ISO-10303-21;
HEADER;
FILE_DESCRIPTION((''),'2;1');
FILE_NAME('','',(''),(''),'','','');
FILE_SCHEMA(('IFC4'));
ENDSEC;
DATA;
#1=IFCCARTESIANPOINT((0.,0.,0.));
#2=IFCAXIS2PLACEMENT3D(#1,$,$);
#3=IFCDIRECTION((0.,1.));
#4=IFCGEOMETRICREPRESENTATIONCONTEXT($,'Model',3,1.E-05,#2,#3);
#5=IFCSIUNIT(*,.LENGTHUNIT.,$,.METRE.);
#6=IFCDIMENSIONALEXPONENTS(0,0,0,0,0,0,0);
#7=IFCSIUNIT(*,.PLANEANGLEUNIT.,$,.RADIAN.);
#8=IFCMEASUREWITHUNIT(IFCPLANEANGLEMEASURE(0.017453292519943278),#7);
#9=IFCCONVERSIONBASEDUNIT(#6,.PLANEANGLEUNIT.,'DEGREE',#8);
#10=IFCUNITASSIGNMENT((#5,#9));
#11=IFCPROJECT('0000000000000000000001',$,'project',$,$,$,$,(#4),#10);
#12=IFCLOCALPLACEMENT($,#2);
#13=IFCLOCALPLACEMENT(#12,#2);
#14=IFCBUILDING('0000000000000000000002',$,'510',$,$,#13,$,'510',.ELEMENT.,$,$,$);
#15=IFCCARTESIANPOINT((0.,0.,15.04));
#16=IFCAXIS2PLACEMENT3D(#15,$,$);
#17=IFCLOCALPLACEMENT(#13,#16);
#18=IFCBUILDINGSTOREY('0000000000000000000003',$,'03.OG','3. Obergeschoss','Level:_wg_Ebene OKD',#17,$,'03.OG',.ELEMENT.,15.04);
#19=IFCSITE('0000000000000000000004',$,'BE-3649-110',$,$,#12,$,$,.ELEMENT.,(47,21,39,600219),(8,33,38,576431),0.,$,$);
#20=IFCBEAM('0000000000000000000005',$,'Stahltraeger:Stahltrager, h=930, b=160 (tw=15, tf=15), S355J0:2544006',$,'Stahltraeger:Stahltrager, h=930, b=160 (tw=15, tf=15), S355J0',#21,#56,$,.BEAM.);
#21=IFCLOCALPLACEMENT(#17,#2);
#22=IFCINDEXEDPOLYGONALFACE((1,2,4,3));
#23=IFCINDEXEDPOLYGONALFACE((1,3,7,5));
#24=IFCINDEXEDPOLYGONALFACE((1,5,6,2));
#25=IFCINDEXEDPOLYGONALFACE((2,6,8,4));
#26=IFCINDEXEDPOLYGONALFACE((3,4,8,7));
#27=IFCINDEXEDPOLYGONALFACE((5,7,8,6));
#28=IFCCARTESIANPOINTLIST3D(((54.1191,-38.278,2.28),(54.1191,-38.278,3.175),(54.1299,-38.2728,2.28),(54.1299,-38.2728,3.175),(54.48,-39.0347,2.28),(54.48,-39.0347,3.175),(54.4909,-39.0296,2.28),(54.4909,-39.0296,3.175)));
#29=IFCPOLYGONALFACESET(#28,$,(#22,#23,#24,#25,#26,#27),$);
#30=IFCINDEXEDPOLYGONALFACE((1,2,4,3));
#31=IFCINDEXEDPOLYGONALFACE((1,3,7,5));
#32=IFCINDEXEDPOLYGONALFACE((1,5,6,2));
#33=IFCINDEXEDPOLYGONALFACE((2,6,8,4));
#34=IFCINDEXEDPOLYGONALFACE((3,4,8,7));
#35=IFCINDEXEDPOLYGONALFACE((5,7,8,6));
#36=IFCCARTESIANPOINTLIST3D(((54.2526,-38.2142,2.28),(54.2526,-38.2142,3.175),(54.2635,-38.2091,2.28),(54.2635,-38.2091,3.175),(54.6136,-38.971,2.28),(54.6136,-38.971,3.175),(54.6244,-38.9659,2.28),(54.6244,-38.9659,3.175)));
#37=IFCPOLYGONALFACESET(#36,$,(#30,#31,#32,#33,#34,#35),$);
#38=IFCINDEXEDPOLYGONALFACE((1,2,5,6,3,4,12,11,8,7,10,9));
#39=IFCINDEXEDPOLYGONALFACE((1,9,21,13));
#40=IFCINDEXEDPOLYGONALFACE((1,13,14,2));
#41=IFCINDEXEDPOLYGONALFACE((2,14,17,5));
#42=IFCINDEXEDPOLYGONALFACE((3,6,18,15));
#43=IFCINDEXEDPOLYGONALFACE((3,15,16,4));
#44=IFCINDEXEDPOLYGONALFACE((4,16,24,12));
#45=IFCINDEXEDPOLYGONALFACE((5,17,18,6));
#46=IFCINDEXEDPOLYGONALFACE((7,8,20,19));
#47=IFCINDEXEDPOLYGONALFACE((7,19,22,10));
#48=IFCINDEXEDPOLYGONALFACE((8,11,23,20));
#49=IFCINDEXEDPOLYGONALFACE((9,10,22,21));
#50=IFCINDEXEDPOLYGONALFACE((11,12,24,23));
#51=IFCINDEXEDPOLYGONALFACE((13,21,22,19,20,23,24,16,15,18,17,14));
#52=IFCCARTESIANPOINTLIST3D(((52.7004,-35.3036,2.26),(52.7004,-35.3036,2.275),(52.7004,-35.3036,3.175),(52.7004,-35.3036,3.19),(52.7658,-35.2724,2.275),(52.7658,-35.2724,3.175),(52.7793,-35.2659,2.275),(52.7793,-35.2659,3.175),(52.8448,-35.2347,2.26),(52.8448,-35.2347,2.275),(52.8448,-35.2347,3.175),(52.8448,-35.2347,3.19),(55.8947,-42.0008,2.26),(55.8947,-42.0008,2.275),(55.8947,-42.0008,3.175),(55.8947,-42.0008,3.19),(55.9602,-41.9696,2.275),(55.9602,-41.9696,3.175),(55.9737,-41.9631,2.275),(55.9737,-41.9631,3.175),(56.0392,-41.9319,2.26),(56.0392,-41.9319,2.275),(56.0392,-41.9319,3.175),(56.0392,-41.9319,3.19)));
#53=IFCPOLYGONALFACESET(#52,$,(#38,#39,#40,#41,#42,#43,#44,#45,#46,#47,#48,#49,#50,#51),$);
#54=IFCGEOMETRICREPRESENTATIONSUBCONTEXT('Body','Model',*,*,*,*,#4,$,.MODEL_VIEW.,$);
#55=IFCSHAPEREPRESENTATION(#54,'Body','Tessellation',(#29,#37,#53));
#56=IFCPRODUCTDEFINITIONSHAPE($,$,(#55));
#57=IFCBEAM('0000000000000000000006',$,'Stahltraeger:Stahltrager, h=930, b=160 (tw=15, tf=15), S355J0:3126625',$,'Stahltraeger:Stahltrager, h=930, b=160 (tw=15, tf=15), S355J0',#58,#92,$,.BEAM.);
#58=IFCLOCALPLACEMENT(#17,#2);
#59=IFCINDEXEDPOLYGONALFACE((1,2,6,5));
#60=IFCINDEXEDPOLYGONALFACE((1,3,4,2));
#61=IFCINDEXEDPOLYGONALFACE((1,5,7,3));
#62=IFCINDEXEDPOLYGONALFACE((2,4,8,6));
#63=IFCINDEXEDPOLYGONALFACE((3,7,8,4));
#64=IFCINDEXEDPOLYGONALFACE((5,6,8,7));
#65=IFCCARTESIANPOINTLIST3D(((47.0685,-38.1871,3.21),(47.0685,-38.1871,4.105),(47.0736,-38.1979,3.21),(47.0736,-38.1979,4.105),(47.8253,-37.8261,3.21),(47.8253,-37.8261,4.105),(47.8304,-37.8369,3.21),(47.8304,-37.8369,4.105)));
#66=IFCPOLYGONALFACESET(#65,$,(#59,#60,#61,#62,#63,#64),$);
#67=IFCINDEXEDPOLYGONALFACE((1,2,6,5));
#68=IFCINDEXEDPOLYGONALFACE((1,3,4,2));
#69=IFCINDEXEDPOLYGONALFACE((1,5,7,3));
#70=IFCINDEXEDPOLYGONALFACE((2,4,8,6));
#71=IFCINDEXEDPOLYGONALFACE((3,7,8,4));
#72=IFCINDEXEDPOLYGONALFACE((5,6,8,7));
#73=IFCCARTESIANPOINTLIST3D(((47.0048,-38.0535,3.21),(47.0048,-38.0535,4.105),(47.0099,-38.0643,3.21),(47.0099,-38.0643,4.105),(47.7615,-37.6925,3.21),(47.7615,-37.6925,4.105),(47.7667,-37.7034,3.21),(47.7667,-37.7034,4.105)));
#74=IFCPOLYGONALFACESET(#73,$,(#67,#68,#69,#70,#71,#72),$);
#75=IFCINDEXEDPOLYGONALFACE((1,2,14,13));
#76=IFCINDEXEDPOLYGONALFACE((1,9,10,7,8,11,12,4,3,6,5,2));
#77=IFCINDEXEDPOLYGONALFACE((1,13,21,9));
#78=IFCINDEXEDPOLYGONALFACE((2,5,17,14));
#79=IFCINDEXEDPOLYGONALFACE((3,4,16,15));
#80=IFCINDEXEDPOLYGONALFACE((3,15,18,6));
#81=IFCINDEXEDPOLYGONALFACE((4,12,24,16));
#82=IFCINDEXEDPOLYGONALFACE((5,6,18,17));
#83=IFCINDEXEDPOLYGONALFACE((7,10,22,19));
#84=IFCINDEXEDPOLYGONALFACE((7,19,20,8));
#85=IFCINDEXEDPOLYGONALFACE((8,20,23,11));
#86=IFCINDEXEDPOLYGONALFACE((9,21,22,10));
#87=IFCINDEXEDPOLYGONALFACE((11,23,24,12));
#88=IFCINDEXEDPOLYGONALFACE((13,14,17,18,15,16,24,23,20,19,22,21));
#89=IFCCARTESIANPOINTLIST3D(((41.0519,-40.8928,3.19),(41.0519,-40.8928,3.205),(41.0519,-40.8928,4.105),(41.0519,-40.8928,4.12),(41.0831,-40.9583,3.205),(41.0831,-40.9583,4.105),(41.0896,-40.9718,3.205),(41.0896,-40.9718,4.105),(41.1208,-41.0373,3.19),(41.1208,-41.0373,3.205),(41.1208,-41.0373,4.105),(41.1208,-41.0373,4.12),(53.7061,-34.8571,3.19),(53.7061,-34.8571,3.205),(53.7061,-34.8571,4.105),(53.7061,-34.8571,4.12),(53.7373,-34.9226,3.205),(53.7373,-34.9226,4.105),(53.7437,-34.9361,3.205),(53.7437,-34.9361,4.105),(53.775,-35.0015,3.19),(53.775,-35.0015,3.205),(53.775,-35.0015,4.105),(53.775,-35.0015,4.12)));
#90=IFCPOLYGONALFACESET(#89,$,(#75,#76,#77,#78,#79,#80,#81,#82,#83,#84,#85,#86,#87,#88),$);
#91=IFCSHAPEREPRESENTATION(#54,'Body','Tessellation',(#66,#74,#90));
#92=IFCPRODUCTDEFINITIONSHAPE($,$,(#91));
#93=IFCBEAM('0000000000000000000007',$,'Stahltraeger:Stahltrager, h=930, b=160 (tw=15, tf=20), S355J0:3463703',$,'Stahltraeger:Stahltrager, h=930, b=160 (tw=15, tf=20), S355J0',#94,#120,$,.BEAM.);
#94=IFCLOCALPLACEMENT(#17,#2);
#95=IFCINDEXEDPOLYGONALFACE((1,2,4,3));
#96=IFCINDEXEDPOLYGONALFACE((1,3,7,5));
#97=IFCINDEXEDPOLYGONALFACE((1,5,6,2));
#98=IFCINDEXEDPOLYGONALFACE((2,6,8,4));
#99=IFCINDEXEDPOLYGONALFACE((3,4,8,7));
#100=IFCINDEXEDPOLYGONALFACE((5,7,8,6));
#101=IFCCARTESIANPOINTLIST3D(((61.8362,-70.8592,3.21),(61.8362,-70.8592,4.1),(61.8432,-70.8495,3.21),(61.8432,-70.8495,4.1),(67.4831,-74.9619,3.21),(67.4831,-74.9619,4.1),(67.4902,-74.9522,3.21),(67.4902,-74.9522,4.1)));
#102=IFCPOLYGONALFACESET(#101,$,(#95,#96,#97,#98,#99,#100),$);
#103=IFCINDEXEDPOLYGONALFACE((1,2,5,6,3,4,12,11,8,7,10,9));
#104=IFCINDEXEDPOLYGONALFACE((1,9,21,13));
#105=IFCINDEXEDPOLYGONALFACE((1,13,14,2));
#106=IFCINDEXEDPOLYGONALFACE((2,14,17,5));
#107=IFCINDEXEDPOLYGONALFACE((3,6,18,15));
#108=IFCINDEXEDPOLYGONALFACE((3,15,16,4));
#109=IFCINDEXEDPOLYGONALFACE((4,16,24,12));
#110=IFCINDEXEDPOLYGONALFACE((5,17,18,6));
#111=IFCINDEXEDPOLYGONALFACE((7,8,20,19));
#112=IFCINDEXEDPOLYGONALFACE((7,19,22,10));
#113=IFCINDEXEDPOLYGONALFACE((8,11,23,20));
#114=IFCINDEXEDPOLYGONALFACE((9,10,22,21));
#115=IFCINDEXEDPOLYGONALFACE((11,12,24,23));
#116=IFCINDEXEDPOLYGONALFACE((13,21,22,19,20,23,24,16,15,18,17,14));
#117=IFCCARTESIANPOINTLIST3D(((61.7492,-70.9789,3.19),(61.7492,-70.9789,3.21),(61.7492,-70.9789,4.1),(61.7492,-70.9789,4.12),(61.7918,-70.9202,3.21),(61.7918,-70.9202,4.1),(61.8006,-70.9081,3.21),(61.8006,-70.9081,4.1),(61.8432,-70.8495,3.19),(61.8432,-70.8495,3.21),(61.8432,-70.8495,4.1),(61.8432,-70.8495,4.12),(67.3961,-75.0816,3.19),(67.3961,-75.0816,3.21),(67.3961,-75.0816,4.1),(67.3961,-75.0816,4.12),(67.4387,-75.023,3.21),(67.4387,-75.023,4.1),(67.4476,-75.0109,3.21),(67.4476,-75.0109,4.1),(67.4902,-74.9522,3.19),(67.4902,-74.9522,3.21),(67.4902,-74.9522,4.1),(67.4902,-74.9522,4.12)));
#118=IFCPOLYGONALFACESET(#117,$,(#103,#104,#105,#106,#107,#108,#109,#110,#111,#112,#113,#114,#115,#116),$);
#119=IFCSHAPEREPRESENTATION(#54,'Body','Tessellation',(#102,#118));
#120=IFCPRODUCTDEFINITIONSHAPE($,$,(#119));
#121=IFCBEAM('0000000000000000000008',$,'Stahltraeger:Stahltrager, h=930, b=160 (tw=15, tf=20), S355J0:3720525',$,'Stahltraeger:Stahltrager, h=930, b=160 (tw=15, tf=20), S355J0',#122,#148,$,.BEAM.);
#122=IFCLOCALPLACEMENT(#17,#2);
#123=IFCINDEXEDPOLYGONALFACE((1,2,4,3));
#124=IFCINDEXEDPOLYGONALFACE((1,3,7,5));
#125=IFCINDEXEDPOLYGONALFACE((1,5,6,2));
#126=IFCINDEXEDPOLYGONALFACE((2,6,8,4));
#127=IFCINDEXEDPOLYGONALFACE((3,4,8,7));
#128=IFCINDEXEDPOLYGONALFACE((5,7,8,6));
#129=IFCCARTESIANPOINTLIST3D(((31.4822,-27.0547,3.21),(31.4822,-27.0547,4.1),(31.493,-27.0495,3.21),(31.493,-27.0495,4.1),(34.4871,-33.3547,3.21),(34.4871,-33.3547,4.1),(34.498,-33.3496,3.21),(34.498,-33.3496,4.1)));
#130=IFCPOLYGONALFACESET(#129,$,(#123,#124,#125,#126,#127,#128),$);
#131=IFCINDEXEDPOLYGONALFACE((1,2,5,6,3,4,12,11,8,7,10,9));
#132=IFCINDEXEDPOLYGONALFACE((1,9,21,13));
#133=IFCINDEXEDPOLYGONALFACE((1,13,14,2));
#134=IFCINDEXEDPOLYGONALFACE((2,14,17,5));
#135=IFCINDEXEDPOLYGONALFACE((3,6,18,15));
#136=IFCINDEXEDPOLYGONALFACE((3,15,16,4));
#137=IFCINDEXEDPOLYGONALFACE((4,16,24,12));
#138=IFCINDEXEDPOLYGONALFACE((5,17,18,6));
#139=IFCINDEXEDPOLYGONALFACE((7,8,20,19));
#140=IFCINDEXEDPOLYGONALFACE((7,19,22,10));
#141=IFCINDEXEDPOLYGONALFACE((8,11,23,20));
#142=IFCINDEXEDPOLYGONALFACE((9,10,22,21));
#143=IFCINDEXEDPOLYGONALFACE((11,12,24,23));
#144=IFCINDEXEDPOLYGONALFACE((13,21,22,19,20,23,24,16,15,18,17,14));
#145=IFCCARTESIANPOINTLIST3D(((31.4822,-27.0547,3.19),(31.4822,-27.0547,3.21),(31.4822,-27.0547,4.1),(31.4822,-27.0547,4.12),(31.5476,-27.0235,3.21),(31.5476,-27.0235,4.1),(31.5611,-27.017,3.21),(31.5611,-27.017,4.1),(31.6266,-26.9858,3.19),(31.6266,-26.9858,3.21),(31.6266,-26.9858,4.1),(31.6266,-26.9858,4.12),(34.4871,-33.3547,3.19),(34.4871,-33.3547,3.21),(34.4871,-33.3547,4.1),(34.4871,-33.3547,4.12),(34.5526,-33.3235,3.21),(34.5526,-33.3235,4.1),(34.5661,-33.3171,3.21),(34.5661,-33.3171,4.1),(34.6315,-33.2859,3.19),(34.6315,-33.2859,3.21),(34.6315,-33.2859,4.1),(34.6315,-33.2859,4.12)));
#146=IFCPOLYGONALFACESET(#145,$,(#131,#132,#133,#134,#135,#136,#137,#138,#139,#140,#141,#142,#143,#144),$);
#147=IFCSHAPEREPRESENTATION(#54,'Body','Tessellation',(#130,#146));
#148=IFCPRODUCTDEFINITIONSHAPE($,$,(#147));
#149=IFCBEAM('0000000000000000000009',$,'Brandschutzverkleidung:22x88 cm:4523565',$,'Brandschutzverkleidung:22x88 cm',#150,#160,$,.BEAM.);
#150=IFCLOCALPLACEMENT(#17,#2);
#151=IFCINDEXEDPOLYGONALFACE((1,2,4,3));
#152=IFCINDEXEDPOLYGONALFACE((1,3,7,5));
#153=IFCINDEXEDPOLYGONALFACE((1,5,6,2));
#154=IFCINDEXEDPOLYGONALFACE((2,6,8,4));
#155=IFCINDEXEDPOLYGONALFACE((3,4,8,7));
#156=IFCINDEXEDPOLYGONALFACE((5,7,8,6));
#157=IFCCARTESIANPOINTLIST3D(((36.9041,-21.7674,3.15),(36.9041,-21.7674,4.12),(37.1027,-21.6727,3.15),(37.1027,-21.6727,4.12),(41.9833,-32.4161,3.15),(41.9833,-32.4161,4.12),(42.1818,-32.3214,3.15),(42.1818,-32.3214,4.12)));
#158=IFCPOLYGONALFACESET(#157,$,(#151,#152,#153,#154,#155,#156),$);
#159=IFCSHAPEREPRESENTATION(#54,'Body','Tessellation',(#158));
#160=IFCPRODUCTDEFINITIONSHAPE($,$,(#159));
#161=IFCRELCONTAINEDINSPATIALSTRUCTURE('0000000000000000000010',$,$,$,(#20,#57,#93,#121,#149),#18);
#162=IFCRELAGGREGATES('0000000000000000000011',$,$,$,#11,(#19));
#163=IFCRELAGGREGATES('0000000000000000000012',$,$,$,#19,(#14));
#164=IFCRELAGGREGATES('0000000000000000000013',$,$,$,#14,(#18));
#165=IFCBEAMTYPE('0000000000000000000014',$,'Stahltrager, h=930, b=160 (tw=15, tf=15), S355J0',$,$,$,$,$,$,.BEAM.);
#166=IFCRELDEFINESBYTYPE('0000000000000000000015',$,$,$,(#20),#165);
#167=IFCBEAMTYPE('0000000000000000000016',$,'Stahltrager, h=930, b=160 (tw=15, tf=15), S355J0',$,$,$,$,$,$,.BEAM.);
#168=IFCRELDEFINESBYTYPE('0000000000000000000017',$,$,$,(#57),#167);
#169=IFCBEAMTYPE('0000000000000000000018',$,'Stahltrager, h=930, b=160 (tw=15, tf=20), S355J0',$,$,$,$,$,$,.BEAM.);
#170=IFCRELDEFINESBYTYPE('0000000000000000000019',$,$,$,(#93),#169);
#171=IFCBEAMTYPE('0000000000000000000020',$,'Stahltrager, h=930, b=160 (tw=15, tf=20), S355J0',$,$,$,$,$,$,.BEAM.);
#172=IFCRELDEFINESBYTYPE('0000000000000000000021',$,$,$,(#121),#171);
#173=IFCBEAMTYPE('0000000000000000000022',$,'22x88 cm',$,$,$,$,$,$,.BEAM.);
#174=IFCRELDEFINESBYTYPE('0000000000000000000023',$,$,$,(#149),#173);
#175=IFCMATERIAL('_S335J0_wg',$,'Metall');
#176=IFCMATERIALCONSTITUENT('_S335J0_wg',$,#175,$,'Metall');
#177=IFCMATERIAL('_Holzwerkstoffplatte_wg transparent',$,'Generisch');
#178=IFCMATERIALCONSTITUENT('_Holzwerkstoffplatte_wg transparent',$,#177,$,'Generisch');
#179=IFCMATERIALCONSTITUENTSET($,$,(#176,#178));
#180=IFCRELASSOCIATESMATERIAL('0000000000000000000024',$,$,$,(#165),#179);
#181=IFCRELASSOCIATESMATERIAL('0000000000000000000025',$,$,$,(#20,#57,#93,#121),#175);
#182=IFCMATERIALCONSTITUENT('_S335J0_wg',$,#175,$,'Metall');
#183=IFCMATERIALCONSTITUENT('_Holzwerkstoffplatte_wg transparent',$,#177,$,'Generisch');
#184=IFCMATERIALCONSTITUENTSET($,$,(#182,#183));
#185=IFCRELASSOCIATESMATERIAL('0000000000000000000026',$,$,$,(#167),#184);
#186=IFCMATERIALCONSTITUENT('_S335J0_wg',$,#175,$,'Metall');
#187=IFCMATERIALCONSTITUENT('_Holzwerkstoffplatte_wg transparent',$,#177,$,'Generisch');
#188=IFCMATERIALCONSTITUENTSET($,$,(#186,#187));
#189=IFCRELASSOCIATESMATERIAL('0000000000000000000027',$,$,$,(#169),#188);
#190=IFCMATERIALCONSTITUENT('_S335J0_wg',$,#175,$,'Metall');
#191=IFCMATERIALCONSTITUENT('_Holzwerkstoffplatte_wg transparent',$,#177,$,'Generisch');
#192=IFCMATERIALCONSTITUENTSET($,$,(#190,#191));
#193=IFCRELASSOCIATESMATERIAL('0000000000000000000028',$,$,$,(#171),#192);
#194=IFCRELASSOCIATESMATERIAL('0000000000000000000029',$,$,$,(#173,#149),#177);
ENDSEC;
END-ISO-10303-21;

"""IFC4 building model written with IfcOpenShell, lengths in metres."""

from ifc_helpers import new_model, entity, si_unit, converted_unit, direction, frame, origin, place, context, subcontext, project, spatial, indexed_curve, outline, extrude, source, transform, mapped, material, constituent, constituent_set, type_object, type_shapes, element, save


model = new_model("IFC4")

# Units and contexts
model_context = context("Model", 3, precision=1e-05, world=origin(), true_north=direction((0.0, 1.0)))
body_context = subcontext(model_context, "Body", "Model", "MODEL_VIEW")
ifc_project = project(units=[si_unit("LENGTHUNIT", "METRE"), converted_unit("PLANEANGLEUNIT", "DEGREE", entity("IfcPlaneAngleMeasure", 0.017453292519943278), si_unit("PLANEANGLEUNIT", "RADIAN"), dimensions=[0, 0, 0, 0, 0, 0, 0])], contexts=[model_context])

# Site, building, storey
site_placement = place(None, origin())
site = spatial("IfcSite", under=ifc_project, at=site_placement, Name="BE-3649-110", CompositionType="ELEMENT", RefLatitude=(47, 21, 39, 600219), RefLongitude=(8, 33, 38, 576431), RefElevation=0.0)
building_placement = place(site_placement, origin())
building = spatial("IfcBuilding", under=site, at=building_placement, Name="510", LongName="510", CompositionType="ELEMENT")
storey_placement = place(building_placement, frame((0.0, 0.0, 15.04)))
storey = spatial("IfcBuildingStorey", under=building, at=storey_placement, Name="03.OG", Description="3. Obergeschoss", ObjectType="Level:_wg_Ebene OKD", LongName="03.OG", CompositionType="ELEMENT", Elevation=15.04)

# Beams
ifc_material_1 = material(Name="_S335J0_wg", Category="Metall")
ifc_constituent_1 = constituent(ifc_material_1, Name="_S335J0_wg", Category="Metall")
ifc_material_2 = material(Name="_Holzwerkstoffplatte_wg transparent", Category="Generisch")
ifc_constituent_2 = constituent(ifc_material_2, Name="_Holzwerkstoffplatte_wg transparent", Category="Generisch")
ifc_constituent_set_1 = constituent_set(constituents=[ifc_constituent_1, ifc_constituent_2])
beam_type_1 = type_object("IfcBeamType", Name="Stahltrager, h=930, b=160 (tw=15, tf=15), S355J0", PredefinedType="BEAM", material=ifc_constituent_set_1)
shared_shape_1 = source(origin(), body_context, "Body", "SweptSolid", [
    extrude(outline(indexed_curve([(-0.4475, -0.006), (0.4475, -0.006), (0.4475, 0.006), (-0.4475, 0.006), (-0.4475, -0.006)], self_intersect=False)), frame((54.1245, -38.2754, 17.7675), z_axis=(0.430511, -0.902585, 0.0), x_axis=(0.0, 0.0, -1.0)), (0.0, 0.0, 1.0), 0.8385),
    extrude(outline(indexed_curve([(-0.4475, -0.006), (0.4475, -0.006), (0.4475, 0.006), (-0.4475, 0.006), (-0.4475, -0.006)], self_intersect=False)), frame((54.2581, -38.2117, 17.7675), z_axis=(0.430511, -0.902585, 0.0), x_axis=(0.0, 0.0, -1.0)), (0.0, 0.0, 1.0), 0.8385),
    extrude(outline(indexed_curve([(-0.465, -0.08), (-0.45, -0.08), (-0.45, -0.0075), (0.45, -0.0075), (0.45, -0.08), (0.465, -0.08), (0.465, 0.08), (0.45, 0.08), (0.45, 0.0075), (-0.45, 0.0075), (-0.45, 0.08), (-0.465, 0.08), (-0.465, -0.08)], self_intersect=False)), frame((52.7726, -35.2691, 17.765), z_axis=(0.430511, -0.902585, 0.0), x_axis=(0.0, 0.0, -1.0)), (0.0, 0.0, 1.0), 7.42),
])
type_shapes(beam_type_1, [shared_shape_1])
beam_1_placement = place(storey_placement, frame((0.0, 0.0, -15.04)))
element("IfcBeam", 1, at=beam_1_placement, inside=storey, type_object=beam_type_1, material=ifc_material_1, Name="Stahltraeger:Stahltrager, h=930, b=160 (tw=15, tf=15), S355J0:2544006", ObjectType="Stahltraeger:Stahltrager, h=930, b=160 (tw=15, tf=15), S355J0", PredefinedType="BEAM", context=body_context, shape_type="MappedRepresentation", body=[
    mapped(shared_shape_1, transform((0.0, 0.0, 0.0), scale=1.0)),
])
ifc_constituent_3 = constituent(ifc_material_1, Name="_S335J0_wg", Category="Metall")
ifc_constituent_4 = constituent(ifc_material_2, Name="_Holzwerkstoffplatte_wg transparent", Category="Generisch")
ifc_constituent_set_2 = constituent_set(constituents=[ifc_constituent_3, ifc_constituent_4])
beam_type_2 = type_object("IfcBeamType", Name="Stahltrager, h=930, b=160 (tw=15, tf=15), S355J0", PredefinedType="BEAM", material=ifc_constituent_set_2)
shared_shape_2 = source(origin(), body_context, "Body", "SweptSolid", [
    extrude(outline(indexed_curve([(-0.4475, -0.006), (0.4475, -0.006), (0.4475, 0.006), (-0.4475, 0.006), (-0.4475, -0.006)], self_intersect=False)), frame((47.0711, -38.1925, 18.6975), z_axis=(0.902585, 0.430511, 0.0), x_axis=(0.0, 0.0, 1.0)), (0.0, 0.0, 1.0), 0.8385),
    extrude(outline(indexed_curve([(-0.4475, -0.006), (0.4475, -0.006), (0.4475, 0.006), (-0.4475, 0.006), (-0.4475, -0.006)], self_intersect=False)), frame((47.0073, -38.0589, 18.6975), z_axis=(0.902585, 0.430511, 0.0), x_axis=(0.0, 0.0, 1.0)), (0.0, 0.0, 1.0), 0.8385),
    extrude(outline(indexed_curve([(0.45, -0.08), (0.465, -0.08), (0.465, 0.08), (0.45, 0.08), (0.45, 0.0075), (-0.45, 0.0075), (-0.45, 0.08), (-0.465, 0.08), (-0.465, -0.08), (-0.45, -0.08), (-0.45, -0.0075), (0.45, -0.0075), (0.45, -0.08)], self_intersect=False)), frame((41.0864, -40.9651, 18.695), z_axis=(0.902585, 0.430511, 0.0), x_axis=(0.0, 0.0, 1.0)), (0.0, 0.0, 1.0), 14.0199),
])
type_shapes(beam_type_2, [shared_shape_2])
beam_2_placement = place(storey_placement, frame((0.0, 0.0, -15.04)))
element("IfcBeam", 2, at=beam_2_placement, inside=storey, type_object=beam_type_2, material=ifc_material_1, Name="Stahltraeger:Stahltrager, h=930, b=160 (tw=15, tf=15), S355J0:3126625", ObjectType="Stahltraeger:Stahltrager, h=930, b=160 (tw=15, tf=15), S355J0", PredefinedType="BEAM", context=body_context, shape_type="MappedRepresentation", body=[
    mapped(shared_shape_2, transform((0.0, 0.0, 0.0), scale=1.0)),
])
ifc_constituent_5 = constituent(ifc_material_1, Name="_S335J0_wg", Category="Metall")
ifc_constituent_6 = constituent(ifc_material_2, Name="_Holzwerkstoffplatte_wg transparent", Category="Generisch")
ifc_constituent_set_3 = constituent_set(constituents=[ifc_constituent_5, ifc_constituent_6])
beam_type_3 = type_object("IfcBeamType", Name="Stahltrager, h=930, b=160 (tw=15, tf=20), S355J0", PredefinedType="BEAM", material=ifc_constituent_set_3)
shared_shape_3 = source(origin(), body_context, "Body", "SweptSolid", [
    extrude(outline(indexed_curve([(-0.445, -0.006), (0.445, -0.006), (0.445, 0.006), (-0.445, 0.006), (-0.445, -0.006)], self_intersect=False)), frame((61.8397, -70.8543, 18.695), z_axis=(0.809017, -0.587785, 0.0), x_axis=(0.0, 0.0, -1.0)), (0.0, 0.0, 1.0), 6.98),
    extrude(outline(indexed_curve([(-0.465, -0.08), (-0.445, -0.08), (-0.445, -0.0075), (0.445, -0.0075), (0.445, -0.08), (0.465, -0.08), (0.465, 0.08), (0.445, 0.08), (0.445, 0.0075), (-0.445, 0.0075), (-0.445, 0.08), (-0.465, 0.08), (-0.465, -0.08)], self_intersect=False)), frame((61.7962, -70.9142, 18.695), z_axis=(0.809017, -0.587785, 0.0), x_axis=(0.0, 0.0, -1.0)), (0.0, 0.0, 1.0), 6.98),
])
type_shapes(beam_type_3, [shared_shape_3])
beam_3_placement = place(storey_placement, frame((0.0, 0.0, -15.04)))
element("IfcBeam", 3, at=beam_3_placement, inside=storey, type_object=beam_type_3, material=ifc_material_1, Name="Stahltraeger:Stahltrager, h=930, b=160 (tw=15, tf=20), S355J0:3463703", ObjectType="Stahltraeger:Stahltrager, h=930, b=160 (tw=15, tf=20), S355J0", PredefinedType="BEAM", context=body_context, shape_type="MappedRepresentation", body=[
    mapped(shared_shape_3, transform((0.0, 0.0, 0.0), scale=1.0)),
])
ifc_constituent_7 = constituent(ifc_material_1, Name="_S335J0_wg", Category="Metall")
ifc_constituent_8 = constituent(ifc_material_2, Name="_Holzwerkstoffplatte_wg transparent", Category="Generisch")
ifc_constituent_set_4 = constituent_set(constituents=[ifc_constituent_7, ifc_constituent_8])
beam_type_4 = type_object("IfcBeamType", Name="Stahltrager, h=930, b=160 (tw=15, tf=20), S355J0", PredefinedType="BEAM", material=ifc_constituent_set_4)
shared_shape_4 = source(origin(), body_context, "Body", "SweptSolid", [
    extrude(outline(indexed_curve([(-0.445, -0.006), (0.445, -0.006), (0.445, 0.006), (-0.445, 0.006), (-0.445, -0.006)], self_intersect=False)), frame((31.4876, -27.0521, 18.695), z_axis=(0.430511, -0.902585, 0.0), x_axis=(0.0, 0.0, -1.0)), (0.0, 0.0, 1.0), 6.98),
    extrude(outline(indexed_curve([(-0.465, -0.08), (-0.445, -0.08), (-0.445, -0.0075), (0.445, -0.0075), (0.445, -0.08), (0.465, -0.08), (0.465, 0.08), (0.445, 0.08), (0.445, 0.0075), (-0.445, 0.0075), (-0.445, 0.08), (-0.465, 0.08), (-0.465, -0.08)], self_intersect=False)), frame((31.5544, -27.0203, 18.695), z_axis=(0.430511, -0.902585, 0.0), x_axis=(0.0, 0.0, -1.0)), (0.0, 0.0, 1.0), 6.98),
])
type_shapes(beam_type_4, [shared_shape_4])
beam_4_placement = place(storey_placement, frame((0.0, 0.0, -15.04)))
element("IfcBeam", 4, at=beam_4_placement, inside=storey, type_object=beam_type_4, material=ifc_material_1, Name="Stahltraeger:Stahltrager, h=930, b=160 (tw=15, tf=20), S355J0:3720525", ObjectType="Stahltraeger:Stahltrager, h=930, b=160 (tw=15, tf=20), S355J0", PredefinedType="BEAM", context=body_context, shape_type="MappedRepresentation", body=[
    mapped(shared_shape_4, transform((0.0, 0.0, 0.0), scale=1.0)),
])
beam_type_5 = type_object("IfcBeamType", Name="22x88 cm", PredefinedType="BEAM", material=ifc_material_2)
shared_shape_5 = source(origin(), body_context, "Body", "SweptSolid", [
    extrude(outline(indexed_curve([(-5.899, -0.11), (5.899, -0.11), (5.899, 0.11), (-5.899, 0.11), (-5.899, -0.11)], self_intersect=False)), frame((39.543, -27.0444, -0.485), z_axis=(0.0, 0.0, 1.0), x_axis=(0.430511, -0.902585, 0.0)), (0.0, 0.0, 1.0), 0.97),
])
type_shapes(beam_type_5, [shared_shape_5])
beam_5_placement = place(storey_placement, frame((0.0, 0.0, 3.635)))
element("IfcBeam", 5, at=beam_5_placement, inside=storey, type_object=beam_type_5, material=ifc_material_2, Name="Brandschutzverkleidung:22x88 cm:4523565", ObjectType="Brandschutzverkleidung:22x88 cm", PredefinedType="BEAM", context=body_context, shape_type="MappedRepresentation", body=[
    mapped(shared_shape_5, transform((0.0, 0.0, 0.0), scale=1.0)),
])

save(model, "model.ifc")
